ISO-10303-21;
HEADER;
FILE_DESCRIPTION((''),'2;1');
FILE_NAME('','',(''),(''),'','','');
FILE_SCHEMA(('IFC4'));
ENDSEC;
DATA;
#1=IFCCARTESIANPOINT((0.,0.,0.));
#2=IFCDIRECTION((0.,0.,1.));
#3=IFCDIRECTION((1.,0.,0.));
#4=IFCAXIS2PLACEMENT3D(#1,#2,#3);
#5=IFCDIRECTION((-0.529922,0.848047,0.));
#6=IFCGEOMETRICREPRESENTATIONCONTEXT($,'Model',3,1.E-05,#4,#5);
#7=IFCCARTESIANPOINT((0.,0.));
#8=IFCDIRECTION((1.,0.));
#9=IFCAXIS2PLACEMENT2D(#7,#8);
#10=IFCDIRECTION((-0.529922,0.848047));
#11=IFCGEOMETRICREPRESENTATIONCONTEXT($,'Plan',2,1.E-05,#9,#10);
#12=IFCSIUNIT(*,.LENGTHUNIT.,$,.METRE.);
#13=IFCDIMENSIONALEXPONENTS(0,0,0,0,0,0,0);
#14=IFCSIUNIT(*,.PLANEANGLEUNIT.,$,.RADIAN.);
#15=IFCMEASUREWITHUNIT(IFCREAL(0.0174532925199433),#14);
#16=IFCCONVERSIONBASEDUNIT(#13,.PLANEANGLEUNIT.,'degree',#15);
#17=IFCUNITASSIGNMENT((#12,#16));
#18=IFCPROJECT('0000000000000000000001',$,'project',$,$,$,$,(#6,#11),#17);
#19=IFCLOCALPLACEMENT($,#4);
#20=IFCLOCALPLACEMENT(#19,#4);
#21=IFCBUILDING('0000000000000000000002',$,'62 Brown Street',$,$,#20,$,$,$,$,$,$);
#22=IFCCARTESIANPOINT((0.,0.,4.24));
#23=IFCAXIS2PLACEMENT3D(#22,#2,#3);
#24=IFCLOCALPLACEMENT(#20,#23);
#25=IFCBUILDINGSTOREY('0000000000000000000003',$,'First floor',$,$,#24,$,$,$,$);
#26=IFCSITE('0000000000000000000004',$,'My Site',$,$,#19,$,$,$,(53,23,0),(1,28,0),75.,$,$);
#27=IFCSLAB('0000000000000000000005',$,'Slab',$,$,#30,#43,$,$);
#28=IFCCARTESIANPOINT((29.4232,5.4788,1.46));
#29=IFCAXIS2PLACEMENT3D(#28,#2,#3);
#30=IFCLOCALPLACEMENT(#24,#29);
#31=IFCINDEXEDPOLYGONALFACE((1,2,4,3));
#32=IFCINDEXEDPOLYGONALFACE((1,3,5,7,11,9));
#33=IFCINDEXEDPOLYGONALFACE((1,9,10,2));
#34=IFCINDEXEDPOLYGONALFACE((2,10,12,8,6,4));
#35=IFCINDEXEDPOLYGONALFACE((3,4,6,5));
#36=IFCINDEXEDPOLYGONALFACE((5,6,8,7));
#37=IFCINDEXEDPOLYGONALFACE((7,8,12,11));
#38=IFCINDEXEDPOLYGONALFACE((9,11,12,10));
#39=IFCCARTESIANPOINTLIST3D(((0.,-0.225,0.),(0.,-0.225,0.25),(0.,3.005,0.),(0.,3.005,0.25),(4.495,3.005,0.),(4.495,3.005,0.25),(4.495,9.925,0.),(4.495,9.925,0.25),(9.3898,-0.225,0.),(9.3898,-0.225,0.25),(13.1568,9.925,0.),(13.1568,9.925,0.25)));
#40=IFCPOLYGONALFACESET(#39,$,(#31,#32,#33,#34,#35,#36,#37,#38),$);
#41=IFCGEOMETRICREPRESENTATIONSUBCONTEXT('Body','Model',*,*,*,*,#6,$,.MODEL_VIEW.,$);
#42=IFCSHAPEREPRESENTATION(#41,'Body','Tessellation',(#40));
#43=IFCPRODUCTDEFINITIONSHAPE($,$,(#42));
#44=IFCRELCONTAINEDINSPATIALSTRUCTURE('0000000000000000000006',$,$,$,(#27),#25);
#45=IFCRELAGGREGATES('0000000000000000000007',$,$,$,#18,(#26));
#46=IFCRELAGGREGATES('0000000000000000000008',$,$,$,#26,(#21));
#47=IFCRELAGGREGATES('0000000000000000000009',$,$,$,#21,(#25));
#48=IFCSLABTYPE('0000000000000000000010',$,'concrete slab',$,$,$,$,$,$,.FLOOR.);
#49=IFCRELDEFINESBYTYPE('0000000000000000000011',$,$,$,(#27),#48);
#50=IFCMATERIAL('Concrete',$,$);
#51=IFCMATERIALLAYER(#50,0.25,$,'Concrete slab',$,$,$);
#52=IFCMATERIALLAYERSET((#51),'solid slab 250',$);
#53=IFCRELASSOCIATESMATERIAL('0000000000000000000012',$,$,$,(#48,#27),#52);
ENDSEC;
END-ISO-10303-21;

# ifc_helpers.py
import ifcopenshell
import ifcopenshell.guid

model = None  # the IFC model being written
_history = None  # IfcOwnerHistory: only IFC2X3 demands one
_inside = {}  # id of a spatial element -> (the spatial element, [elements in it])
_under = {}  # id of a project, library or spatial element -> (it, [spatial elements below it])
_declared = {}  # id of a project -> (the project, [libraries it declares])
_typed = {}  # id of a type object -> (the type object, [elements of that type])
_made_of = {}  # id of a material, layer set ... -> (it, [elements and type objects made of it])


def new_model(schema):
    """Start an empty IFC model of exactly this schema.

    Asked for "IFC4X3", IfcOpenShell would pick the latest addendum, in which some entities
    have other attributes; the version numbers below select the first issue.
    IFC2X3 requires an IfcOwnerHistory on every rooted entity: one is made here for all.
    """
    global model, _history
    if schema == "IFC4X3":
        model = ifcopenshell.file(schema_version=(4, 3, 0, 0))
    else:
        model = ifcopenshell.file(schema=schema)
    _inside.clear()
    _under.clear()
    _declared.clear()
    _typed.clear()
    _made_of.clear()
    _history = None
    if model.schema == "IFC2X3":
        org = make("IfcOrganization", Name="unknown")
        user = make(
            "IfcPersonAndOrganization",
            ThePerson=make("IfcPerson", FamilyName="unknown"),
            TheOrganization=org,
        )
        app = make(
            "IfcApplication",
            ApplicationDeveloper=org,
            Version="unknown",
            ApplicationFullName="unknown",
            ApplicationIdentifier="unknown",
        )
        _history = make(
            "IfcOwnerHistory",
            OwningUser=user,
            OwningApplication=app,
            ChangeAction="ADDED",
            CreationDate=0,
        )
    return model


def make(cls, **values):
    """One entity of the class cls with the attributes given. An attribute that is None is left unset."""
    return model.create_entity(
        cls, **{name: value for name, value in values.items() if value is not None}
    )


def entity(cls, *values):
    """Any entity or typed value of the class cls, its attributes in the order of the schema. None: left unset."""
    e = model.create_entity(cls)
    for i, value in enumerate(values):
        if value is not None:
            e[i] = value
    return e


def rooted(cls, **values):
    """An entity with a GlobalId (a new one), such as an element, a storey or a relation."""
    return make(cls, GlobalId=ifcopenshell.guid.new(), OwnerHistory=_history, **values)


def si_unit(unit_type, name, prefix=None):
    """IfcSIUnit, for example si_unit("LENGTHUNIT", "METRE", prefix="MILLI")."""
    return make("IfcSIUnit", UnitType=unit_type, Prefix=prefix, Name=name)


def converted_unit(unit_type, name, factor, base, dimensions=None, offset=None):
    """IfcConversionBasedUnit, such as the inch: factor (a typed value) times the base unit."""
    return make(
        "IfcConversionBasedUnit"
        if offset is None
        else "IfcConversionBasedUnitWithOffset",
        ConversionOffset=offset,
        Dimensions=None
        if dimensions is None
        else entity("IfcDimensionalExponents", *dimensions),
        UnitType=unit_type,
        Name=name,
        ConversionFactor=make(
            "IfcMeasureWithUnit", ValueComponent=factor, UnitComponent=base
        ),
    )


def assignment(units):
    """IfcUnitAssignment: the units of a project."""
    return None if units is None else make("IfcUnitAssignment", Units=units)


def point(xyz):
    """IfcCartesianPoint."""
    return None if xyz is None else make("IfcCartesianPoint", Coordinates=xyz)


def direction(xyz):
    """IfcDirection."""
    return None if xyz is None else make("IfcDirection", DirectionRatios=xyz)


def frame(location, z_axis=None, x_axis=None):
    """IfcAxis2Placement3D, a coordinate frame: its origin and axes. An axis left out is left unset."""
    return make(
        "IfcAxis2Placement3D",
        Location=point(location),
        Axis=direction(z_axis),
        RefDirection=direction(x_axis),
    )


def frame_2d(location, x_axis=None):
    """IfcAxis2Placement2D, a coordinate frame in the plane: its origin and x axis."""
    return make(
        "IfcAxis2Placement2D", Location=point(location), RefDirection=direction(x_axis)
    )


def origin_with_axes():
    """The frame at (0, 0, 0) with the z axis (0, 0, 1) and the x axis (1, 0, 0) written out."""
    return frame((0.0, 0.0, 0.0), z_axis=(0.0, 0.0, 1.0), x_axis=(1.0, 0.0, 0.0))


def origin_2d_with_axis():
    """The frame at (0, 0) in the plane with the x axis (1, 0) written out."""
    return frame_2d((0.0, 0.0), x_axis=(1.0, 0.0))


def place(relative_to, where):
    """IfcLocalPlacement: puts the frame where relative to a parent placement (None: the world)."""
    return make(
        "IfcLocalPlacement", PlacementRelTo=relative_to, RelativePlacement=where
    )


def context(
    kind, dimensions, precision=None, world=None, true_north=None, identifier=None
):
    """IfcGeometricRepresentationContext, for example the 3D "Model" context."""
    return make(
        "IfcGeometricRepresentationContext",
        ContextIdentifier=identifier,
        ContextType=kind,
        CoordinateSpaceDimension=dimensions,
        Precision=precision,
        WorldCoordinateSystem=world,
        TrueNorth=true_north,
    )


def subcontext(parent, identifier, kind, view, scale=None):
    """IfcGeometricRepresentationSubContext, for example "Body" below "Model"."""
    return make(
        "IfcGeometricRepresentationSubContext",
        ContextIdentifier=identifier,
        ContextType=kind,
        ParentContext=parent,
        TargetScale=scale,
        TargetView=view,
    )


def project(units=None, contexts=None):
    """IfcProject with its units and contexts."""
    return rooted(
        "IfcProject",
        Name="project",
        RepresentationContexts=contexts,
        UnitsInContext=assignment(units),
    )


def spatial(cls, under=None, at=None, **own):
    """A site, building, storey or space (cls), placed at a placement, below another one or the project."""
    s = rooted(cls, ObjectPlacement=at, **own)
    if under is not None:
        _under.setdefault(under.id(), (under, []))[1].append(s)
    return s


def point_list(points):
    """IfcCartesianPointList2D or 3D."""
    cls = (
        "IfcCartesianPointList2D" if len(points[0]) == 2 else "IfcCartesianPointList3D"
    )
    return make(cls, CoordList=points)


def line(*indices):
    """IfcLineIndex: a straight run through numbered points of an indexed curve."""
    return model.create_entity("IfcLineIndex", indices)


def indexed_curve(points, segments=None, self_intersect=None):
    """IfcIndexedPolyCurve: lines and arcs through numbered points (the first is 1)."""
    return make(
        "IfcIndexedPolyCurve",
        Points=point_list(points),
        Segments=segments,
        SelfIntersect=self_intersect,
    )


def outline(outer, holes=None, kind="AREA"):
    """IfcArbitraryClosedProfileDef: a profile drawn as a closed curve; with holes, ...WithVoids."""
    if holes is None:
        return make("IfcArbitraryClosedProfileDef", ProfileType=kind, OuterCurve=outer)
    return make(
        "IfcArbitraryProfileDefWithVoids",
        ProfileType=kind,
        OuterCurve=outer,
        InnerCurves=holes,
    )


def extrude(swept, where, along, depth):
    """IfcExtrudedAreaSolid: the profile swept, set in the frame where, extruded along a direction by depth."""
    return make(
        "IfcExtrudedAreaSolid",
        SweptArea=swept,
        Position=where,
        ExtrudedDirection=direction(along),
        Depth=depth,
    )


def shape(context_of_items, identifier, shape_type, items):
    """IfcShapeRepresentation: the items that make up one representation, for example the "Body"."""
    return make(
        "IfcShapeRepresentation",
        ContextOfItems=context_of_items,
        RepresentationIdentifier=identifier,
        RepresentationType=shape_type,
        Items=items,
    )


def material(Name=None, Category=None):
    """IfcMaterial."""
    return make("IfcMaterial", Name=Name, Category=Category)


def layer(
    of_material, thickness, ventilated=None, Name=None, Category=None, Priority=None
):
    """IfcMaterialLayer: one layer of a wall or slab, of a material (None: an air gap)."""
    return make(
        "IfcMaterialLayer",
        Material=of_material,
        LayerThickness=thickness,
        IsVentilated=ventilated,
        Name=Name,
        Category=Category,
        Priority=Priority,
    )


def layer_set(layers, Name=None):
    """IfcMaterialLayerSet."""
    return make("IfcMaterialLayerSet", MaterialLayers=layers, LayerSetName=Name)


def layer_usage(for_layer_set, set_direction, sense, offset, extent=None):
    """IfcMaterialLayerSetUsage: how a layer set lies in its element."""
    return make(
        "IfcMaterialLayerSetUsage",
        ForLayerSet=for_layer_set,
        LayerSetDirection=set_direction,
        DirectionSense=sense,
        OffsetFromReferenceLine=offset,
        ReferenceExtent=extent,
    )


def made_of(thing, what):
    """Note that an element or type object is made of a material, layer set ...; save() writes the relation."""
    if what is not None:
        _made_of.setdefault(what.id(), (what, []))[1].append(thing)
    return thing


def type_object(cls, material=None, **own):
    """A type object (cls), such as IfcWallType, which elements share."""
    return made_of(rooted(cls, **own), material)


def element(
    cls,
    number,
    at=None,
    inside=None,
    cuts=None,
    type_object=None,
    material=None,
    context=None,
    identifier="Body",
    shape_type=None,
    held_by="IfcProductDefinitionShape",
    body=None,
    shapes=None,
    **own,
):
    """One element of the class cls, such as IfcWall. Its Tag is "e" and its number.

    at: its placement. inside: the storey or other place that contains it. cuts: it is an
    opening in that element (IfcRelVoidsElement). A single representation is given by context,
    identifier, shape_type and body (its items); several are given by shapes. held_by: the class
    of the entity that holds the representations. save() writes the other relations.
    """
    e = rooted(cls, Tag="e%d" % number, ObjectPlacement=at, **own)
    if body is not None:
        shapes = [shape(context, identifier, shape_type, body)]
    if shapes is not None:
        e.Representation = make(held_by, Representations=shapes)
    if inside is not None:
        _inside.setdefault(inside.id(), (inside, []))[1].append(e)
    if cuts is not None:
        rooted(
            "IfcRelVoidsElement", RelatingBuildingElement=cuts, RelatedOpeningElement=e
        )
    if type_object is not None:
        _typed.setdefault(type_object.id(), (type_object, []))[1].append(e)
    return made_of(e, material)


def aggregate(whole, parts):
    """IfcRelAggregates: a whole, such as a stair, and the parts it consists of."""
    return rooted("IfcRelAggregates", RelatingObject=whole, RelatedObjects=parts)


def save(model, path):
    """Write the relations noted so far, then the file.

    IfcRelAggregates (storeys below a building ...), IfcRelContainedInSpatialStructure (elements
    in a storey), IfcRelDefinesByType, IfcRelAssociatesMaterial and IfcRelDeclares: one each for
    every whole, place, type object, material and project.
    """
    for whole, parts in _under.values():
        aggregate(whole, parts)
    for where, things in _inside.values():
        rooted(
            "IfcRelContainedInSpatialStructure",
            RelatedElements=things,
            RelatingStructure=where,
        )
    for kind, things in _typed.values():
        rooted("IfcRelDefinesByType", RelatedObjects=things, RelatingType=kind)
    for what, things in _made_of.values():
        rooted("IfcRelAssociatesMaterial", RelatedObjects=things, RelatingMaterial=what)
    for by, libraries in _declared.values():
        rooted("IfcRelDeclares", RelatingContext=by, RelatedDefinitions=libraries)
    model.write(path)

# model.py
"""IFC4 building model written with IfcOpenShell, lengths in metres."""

from ifc_helpers import new_model, entity, si_unit, converted_unit, direction, frame, origin_with_axes, origin_2d_with_axis, place, context, subcontext, project, spatial, line, indexed_curve, outline, extrude, material, layer, layer_set, layer_usage, type_object, element, save


model = new_model("IFC4")

# Units and contexts
model_context = context("Model", 3, precision=1e-05, world=origin_with_axes(), true_north=direction((-0.529922, 0.848047, 0.0)))
plan_context = context("Plan", 2, precision=1e-05, world=origin_2d_with_axis(), true_north=direction((-0.529922, 0.848047)))
body_context_1 = subcontext(model_context, "Body", "Model", "MODEL_VIEW")
ifc_project = project(units=[si_unit("LENGTHUNIT", "METRE"), converted_unit("PLANEANGLEUNIT", "degree", entity("IfcReal", 0.0174532925199433), si_unit("PLANEANGLEUNIT", "RADIAN"), dimensions=[0, 0, 0, 0, 0, 0, 0])], contexts=[model_context, plan_context])

# Site, building, storey
site_placement = place(None, origin_with_axes())
site = spatial("IfcSite", under=ifc_project, at=site_placement, Name="My Site", RefLatitude=(53, 23, 0), RefLongitude=(1, 28, 0), RefElevation=75.0)
building_placement = place(site_placement, origin_with_axes())
building = spatial("IfcBuilding", under=site, at=building_placement, Name="62 Brown Street")
storey_placement = place(building_placement, frame((0.0, 0.0, 4.24), z_axis=(0.0, 0.0, 1.0), x_axis=(1.0, 0.0, 0.0)))
storey = spatial("IfcBuildingStorey", under=building, at=storey_placement, Name="First floor")

# Slab
ifc_material_1 = material(Name="Concrete")
ifc_layer_1 = layer(ifc_material_1, 0.25, Name="Concrete slab")
ifc_layer_set_1 = layer_set([ifc_layer_1], Name="solid slab 250")
slab_type = type_object("IfcSlabType", Name="concrete slab", PredefinedType="FLOOR", material=ifc_layer_set_1)
ifc_layer_usage_1 = layer_usage(ifc_layer_set_1, "AXIS3", "POSITIVE", 0.0)
slab_1_placement = place(storey_placement, frame((29.4232, 5.4788, 1.46), z_axis=(0.0, 0.0, 1.0), x_axis=(1.0, 0.0, 0.0)))
element("IfcSlab", 1, at=slab_1_placement, inside=storey, type_object=slab_type, material=ifc_layer_usage_1, Name="Slab", context=body_context_1, shape_type="SweptSolid", body=[
    extrude(outline(indexed_curve([(0.0, 3.005), (0.0, -0.225), (9.3898, -0.225), (13.1568, 9.925), (4.495, 9.925), (4.495, 3.005)], segments=[line(4, 3), line(3, 2), line(2, 1), line(1, 6), line(6, 5), line(5, 4)], self_intersect=False)), None, (0.0, 0.0, 1.0), 0.25),
])

save(model, "model.ifc")
